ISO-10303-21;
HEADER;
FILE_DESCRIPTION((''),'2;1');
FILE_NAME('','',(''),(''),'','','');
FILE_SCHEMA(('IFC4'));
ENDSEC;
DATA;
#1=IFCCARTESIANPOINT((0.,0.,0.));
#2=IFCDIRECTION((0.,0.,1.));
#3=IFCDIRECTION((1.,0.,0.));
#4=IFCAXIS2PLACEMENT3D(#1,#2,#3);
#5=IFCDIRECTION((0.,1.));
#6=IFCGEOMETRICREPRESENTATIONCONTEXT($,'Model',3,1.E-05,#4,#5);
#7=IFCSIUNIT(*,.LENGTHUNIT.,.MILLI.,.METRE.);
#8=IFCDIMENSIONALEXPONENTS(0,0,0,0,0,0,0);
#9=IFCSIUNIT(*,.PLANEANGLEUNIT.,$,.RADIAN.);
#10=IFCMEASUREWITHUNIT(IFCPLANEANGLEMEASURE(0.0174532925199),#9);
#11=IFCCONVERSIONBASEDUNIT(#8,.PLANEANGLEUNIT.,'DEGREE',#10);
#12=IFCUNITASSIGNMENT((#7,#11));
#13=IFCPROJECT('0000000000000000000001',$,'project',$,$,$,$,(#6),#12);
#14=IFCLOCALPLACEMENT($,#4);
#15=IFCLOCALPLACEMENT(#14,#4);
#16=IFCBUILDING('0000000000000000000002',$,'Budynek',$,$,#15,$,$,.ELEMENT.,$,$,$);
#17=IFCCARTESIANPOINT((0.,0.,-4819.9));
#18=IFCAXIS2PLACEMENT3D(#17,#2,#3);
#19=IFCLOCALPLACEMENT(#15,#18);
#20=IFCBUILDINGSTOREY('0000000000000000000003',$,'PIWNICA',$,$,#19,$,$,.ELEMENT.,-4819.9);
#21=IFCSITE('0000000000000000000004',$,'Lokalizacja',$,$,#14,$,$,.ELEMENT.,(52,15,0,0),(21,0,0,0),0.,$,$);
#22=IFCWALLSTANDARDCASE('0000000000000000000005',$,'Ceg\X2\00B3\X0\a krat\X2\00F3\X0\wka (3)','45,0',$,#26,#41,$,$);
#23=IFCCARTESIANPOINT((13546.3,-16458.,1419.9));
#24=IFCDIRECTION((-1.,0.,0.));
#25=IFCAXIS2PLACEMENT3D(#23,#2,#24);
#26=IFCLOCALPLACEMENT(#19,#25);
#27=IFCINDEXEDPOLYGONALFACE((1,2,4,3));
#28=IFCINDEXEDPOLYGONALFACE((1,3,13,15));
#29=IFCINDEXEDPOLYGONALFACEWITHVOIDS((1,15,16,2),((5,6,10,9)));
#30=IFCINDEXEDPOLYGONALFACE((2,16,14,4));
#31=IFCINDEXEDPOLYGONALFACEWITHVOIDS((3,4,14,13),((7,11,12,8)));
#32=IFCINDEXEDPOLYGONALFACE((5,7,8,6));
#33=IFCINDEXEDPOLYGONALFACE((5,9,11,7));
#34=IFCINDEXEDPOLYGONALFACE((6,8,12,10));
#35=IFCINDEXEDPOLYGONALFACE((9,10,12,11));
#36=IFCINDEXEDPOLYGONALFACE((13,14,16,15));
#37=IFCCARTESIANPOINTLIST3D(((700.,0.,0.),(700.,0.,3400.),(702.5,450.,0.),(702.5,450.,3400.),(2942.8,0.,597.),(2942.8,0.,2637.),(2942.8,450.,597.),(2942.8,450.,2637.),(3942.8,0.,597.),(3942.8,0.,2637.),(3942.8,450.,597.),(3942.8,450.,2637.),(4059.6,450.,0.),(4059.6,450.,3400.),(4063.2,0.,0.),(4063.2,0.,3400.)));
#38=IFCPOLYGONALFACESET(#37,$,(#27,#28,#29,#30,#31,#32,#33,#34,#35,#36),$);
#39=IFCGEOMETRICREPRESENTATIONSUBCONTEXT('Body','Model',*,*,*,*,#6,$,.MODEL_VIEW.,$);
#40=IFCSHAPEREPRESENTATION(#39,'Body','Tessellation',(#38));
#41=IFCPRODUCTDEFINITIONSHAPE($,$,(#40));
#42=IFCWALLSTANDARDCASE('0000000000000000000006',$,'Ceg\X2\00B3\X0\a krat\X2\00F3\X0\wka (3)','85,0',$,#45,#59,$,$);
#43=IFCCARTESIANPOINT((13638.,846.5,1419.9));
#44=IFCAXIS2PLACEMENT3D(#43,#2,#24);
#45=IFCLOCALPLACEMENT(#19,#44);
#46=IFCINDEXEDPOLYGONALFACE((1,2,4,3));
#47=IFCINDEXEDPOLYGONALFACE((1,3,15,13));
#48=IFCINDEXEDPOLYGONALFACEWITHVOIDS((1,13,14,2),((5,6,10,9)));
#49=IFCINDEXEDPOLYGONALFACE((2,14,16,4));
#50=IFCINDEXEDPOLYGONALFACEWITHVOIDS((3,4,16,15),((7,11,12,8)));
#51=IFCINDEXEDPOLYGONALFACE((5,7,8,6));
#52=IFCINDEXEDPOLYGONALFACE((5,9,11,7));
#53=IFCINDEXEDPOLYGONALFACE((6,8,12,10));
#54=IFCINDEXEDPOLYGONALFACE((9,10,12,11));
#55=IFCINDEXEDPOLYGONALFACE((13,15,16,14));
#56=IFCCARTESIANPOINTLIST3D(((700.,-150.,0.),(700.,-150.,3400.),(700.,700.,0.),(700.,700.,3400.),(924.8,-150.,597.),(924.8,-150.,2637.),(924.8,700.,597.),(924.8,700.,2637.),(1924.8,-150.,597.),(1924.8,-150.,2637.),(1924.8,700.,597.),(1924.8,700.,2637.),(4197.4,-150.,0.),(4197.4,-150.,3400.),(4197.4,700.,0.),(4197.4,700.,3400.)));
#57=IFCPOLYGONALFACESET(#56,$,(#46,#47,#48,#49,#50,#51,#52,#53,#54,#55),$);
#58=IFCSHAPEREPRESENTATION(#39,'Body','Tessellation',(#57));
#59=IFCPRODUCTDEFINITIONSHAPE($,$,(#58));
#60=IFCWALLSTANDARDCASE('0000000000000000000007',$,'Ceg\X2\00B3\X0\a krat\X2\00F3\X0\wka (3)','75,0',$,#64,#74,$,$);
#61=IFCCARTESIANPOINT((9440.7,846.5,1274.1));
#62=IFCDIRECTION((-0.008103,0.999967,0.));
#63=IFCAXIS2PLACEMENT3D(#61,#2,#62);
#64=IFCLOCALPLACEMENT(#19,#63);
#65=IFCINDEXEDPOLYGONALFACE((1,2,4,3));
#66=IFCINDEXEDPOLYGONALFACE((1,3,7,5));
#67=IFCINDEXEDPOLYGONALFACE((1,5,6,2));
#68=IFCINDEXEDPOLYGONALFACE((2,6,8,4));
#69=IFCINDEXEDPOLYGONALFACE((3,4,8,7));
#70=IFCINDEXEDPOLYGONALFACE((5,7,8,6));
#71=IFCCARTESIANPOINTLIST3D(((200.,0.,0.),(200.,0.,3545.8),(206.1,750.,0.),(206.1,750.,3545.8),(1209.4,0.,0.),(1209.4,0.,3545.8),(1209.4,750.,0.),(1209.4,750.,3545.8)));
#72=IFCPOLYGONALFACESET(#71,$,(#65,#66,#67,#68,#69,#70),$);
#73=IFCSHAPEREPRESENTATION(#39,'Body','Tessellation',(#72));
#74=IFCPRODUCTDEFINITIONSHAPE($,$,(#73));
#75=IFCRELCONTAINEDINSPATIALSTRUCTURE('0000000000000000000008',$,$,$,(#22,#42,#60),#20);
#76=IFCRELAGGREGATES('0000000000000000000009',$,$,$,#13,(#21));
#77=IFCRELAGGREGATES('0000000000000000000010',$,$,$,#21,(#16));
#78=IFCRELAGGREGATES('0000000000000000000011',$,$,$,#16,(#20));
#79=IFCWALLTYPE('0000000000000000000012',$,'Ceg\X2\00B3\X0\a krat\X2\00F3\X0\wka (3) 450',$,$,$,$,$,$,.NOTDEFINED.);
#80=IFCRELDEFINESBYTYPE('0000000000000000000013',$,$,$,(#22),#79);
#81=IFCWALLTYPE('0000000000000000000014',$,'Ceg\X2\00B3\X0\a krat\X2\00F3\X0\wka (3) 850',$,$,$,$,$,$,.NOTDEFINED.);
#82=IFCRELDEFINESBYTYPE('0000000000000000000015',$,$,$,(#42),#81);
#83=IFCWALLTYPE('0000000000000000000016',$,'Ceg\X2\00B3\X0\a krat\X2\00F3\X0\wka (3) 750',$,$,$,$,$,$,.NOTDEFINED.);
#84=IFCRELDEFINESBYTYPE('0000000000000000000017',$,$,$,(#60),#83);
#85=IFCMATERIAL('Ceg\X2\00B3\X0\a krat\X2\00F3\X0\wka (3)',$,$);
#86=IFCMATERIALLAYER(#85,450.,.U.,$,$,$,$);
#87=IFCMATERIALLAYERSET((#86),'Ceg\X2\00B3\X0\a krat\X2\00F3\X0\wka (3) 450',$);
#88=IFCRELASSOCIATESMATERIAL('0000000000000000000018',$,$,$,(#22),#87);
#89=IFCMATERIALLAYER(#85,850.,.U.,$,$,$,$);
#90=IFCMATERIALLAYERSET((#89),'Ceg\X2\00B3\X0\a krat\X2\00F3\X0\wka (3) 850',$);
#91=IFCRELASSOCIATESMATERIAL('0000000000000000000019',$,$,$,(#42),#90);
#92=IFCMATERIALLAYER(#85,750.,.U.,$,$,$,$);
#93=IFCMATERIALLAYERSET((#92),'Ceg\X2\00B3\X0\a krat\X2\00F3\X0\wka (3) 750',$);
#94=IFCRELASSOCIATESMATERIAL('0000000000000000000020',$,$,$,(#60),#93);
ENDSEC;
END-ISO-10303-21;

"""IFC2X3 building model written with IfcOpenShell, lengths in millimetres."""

from ifc_helpers import new_model, entity, si_unit, converted_unit, direction, frame, origin_with_axes, origin_2d_with_axis, place, context, subcontext, project, spatial, polyline, rectangle, outline, extrude, material, layer, layer_set, layer_usage, type_object, element, save


model = new_model("IFC2X3")

# Units and contexts
model_context = context("Model", 3, precision=1e-05, world=origin_with_axes(), true_north=direction((0.0, 1.0)))
body_context = subcontext(model_context, "Body", "Model", "MODEL_VIEW")
ifc_project = project(units=[si_unit("LENGTHUNIT", "METRE", prefix="MILLI"), converted_unit("PLANEANGLEUNIT", "DEGREE", entity("IfcPlaneAngleMeasure", 0.0174532925199), si_unit("PLANEANGLEUNIT", "RADIAN"), dimensions=[0, 0, 0, 0, 0, 0, 0])], contexts=[model_context])

# Site, building, storey
site_placement = place(None, origin_with_axes())
site = spatial("IfcSite", under=ifc_project, at=site_placement, Name="Lokalizacja", CompositionType="ELEMENT", RefLatitude=(52, 15, 0, 0), RefLongitude=(21, 0, 0, 0), RefElevation=0.0)
building_placement = place(site_placement, origin_with_axes())
building = spatial("IfcBuilding", under=site, at=building_placement, Name="Budynek", CompositionType="ELEMENT")
storey_placement = place(building_placement, frame((0.0, 0.0, -4819.9), z_axis=(0.0, 0.0, 1.0), x_axis=(1.0, 0.0, 0.0)))
storey = spatial("IfcBuildingStorey", under=building, at=storey_placement, Name="PIWNICA", CompositionType="ELEMENT", Elevation=-4819.9)

# Shared definitions
ifc_material_1 = material(Name="Ceg³a kratówka (3)")
ifc_layer_1 = layer(ifc_material_1, 450.0, ventilated="UNKNOWN")
ifc_layer_set_1 = layer_set([ifc_layer_1], Name="Ceg³a kratówka (3) 450")
wall_type_1 = type_object("IfcWallType", Name="Ceg³a kratówka (3) 450", PredefinedType="NOTDEFINED")

# Wall, opening
ifc_layer_usage_1 = layer_usage(ifc_layer_set_1, "AXIS2", "POSITIVE", 0.0)
wall_1_placement = place(storey_placement, frame((13546.3, -16458.0, 1419.9), z_axis=(0.0, 0.0, 1.0), x_axis=(-1.0, 0.0, 0.0)))
wall_1 = element("IfcWallStandardCase", 1, at=wall_1_placement, inside=storey, type_object=wall_type_1, material=ifc_layer_usage_1, Name="Ceg³a kratówka (3)", Description="45,0", context=body_context, shape_type="SweptSolid", body=[
    extrude(outline(polyline([(700.0, 0.0), (4063.2, 0.0), (4059.6, 450.0), (702.5, 450.0), (700.0, 0.0)])), origin_with_axes(), (0.0, 0.0, 1.0), 3400.0),
])
opening_1_placement = place(wall_1_placement, frame((3442.8, 0.0, 597.0), z_axis=(0.0, 0.0, 1.0), x_axis=(1.0, 0.0, 0.0)))
element("IfcOpeningElement", 2, at=opening_1_placement, cuts=wall_1, context=body_context, shape_type="SweptSolid", body=[
    extrude(rectangle(XDim=1000.0, YDim=2040.0, at=origin_2d_with_axis()), frame((0.0, -450.0, 1020.0), z_axis=(0.0, 1.0, 0.0), x_axis=(1.0, 0.0, 0.0)), (0.0, 0.0, 1.0), 1350.0),
    extrude(rectangle(XDim=1160.0, YDim=2060.0, at=origin_2d_with_axis()), frame((0.0, 0.0, 1030.0), z_axis=(0.0, 1.0, 0.0), x_axis=(1.0, 0.0, 0.0)), (0.0, 0.0, -1.0), 450.0),
    extrude(rectangle(XDim=1120.0, YDim=2060.0, at=origin_2d_with_axis()), frame((0.0, 450.0, 1030.0), z_axis=(0.0, -1.0, 0.0), x_axis=(1.0, 0.0, 0.0)), (0.0, 0.0, -1.0), 450.0),
])

# Wall, opening
ifc_layer_2 = layer(ifc_material_1, 850.0, ventilated="UNKNOWN")
ifc_layer_set_2 = layer_set([ifc_layer_2], Name="Ceg³a kratówka (3) 850")
ifc_layer_usage_2 = layer_usage(ifc_layer_set_2, "AXIS2", "POSITIVE", -150.0)
wall_type_2 = type_object("IfcWallType", Name="Ceg³a kratówka (3) 850", PredefinedType="NOTDEFINED")
wall_2_placement = place(storey_placement, frame((13638.0, 846.5, 1419.9), z_axis=(0.0, 0.0, 1.0), x_axis=(-1.0, 0.0, 0.0)))
wall_2 = element("IfcWallStandardCase", 3, at=wall_2_placement, inside=storey, type_object=wall_type_2, material=ifc_layer_usage_2, Name="Ceg³a kratówka (3)", Description="85,0", context=body_context, shape_type="SweptSolid", body=[
    extrude(outline(polyline([(700.0, -150.0), (4197.4, -150.0), (4197.4, 700.0), (700.0, 700.0), (700.0, -150.0)])), origin_with_axes(), (0.0, 0.0, 1.0), 3400.0),
])
opening_2_placement = place(wall_2_placement, frame((1424.8, 0.0, 597.0), z_axis=(0.0, 0.0, 1.0), x_axis=(1.0, 0.0, 0.0)))
element("IfcOpeningElement", 4, at=opening_2_placement, cuts=wall_2, context=body_context, shape_type="SweptSolid", body=[
    extrude(rectangle(XDim=1000.0, YDim=2040.0, at=origin_2d_with_axis()), frame((0.0, 850.0, 1020.0), z_axis=(0.0, 1.0, 0.0), x_axis=(1.0, 0.0, 0.0)), (0.0, 0.0, -1.0), 2550.0),
    extrude(rectangle(XDim=1160.0, YDim=2060.0, at=origin_2d_with_axis()), frame((0.0, 700.0, 1030.0), z_axis=(0.0, 1.0, 0.0), x_axis=(1.0, 0.0, 0.0)), (0.0, 0.0, 1.0), 850.0),
    extrude(rectangle(XDim=1120.0, YDim=2060.0, at=origin_2d_with_axis()), frame((0.0, -150.0, 1030.0), z_axis=(0.0, -1.0, 0.0), x_axis=(1.0, 0.0, 0.0)), (0.0, 0.0, 1.0), 850.0),
])

# Wall
ifc_layer_3 = layer(ifc_material_1, 750.0, ventilated="UNKNOWN")
ifc_layer_set_3 = layer_set([ifc_layer_3], Name="Ceg³a kratówka (3) 750")
ifc_layer_usage_3 = layer_usage(ifc_layer_set_3, "AXIS2", "POSITIVE", 0.0)
wall_type_3 = type_object("IfcWallType", Name="Ceg³a kratówka (3) 750", PredefinedType="NOTDEFINED")
wall_3_placement = place(storey_placement, frame((9440.7, 846.5, 1274.1), z_axis=(0.0, 0.0, 1.0), x_axis=(-0.008103, 0.999967, 0.0)))
element("IfcWallStandardCase", 5, at=wall_3_placement, inside=storey, type_object=wall_type_3, material=ifc_layer_usage_3, Name="Ceg³a kratówka (3)", Description="75,0", context=body_context, shape_type="SweptSolid", body=[
    extrude(outline(polyline([(200.0, 0.0), (1209.4, 0.0), (1209.4, 750.0), (206.1, 750.0), (200.0, 0.0)])), origin_with_axes(), (0.0, 0.0, 1.0), 3545.8),
])

save(model, "model.ifc")
